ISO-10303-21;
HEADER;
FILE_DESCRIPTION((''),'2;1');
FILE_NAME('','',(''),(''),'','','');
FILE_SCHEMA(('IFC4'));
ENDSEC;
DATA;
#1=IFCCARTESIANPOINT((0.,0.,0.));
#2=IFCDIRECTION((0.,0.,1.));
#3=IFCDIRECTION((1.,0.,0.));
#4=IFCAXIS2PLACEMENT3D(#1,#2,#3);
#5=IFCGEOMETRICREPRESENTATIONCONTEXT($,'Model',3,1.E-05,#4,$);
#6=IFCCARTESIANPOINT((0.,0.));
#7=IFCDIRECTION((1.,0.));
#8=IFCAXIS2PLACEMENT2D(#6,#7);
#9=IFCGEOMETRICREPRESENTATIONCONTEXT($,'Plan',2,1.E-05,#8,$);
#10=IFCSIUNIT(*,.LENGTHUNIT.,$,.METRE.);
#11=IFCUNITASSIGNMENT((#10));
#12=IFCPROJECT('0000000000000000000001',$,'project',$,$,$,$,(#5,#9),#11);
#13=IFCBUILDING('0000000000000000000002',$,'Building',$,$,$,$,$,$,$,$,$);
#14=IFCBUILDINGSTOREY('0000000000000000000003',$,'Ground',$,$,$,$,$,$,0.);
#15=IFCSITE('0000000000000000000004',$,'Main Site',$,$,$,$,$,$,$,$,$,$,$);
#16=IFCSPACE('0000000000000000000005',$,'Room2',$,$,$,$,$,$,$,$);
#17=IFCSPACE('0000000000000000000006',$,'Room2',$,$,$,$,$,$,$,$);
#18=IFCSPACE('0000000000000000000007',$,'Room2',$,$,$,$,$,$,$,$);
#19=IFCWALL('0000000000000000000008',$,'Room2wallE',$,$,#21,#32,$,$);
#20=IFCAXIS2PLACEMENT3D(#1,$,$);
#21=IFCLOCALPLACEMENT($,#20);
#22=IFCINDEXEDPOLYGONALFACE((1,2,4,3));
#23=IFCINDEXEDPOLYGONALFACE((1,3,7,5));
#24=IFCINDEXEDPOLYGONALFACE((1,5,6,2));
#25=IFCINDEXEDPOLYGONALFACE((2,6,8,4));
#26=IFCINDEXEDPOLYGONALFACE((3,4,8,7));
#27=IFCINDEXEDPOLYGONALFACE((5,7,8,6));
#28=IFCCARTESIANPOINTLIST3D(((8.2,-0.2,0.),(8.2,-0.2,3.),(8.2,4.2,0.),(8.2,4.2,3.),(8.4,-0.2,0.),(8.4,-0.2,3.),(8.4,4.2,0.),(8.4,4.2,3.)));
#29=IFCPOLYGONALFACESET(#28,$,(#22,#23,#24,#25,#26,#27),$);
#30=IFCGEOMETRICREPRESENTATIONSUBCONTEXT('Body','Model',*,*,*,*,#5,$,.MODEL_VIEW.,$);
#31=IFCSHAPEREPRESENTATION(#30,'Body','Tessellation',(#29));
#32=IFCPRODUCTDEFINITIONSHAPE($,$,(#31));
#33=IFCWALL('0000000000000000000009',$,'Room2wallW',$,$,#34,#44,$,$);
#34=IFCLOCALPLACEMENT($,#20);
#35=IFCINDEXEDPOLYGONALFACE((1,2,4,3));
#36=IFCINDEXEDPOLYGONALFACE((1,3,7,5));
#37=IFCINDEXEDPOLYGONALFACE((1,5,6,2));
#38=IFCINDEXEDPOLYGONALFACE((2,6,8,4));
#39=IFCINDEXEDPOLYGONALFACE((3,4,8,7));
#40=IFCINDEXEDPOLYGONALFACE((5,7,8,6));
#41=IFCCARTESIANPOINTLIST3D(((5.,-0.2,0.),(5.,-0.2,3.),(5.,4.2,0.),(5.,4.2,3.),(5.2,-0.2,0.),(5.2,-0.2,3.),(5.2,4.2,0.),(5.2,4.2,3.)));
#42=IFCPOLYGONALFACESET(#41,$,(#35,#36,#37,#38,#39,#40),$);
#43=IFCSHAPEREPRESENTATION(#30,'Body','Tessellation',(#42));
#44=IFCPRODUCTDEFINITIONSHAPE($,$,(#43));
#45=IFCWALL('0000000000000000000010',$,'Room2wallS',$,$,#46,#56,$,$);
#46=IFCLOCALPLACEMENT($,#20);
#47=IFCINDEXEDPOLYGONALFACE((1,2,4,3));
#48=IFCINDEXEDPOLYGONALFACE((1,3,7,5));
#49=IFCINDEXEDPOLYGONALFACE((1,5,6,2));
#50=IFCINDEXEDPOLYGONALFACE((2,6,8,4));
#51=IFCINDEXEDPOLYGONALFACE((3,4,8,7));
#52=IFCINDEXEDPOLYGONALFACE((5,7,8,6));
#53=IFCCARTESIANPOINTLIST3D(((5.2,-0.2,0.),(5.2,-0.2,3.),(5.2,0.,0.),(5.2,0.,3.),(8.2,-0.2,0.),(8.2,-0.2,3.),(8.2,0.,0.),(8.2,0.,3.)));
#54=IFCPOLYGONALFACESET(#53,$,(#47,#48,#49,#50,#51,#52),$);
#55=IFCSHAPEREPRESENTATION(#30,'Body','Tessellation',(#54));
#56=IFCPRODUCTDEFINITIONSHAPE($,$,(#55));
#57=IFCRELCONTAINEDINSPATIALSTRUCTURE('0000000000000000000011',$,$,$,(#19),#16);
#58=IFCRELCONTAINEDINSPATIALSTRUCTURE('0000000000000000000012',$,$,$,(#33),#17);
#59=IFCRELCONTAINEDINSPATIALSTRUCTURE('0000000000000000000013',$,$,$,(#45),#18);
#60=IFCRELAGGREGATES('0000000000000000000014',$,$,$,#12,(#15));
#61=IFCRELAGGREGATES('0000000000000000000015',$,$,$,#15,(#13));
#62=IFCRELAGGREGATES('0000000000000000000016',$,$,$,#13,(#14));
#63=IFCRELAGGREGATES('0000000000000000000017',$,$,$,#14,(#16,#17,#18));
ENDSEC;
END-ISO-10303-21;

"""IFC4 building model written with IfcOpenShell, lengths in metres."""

from ifc_helpers import new_model, si_unit, frame, origin_with_axes, origin_2d_with_axis, place, context, subcontext, project, spatial, indexed_curve, outline, extrude, element, save


model = new_model("IFC4")

# Units and contexts
model_context = context("Model", 3, precision=1e-05, world=origin_with_axes())
plan_context = context("Plan", 2, precision=1e-05, world=origin_2d_with_axis())
body_context = subcontext(model_context, "Body", "Model", "MODEL_VIEW")
ifc_project = project(units=[si_unit("LENGTHUNIT", "METRE")], contexts=[model_context, plan_context])

# Site, building, storey, space
site = spatial("IfcSite", under=ifc_project, Name="Main Site")
building = spatial("IfcBuilding", under=site, Name="Building")
storey = spatial("IfcBuildingStorey", under=building, Name="Ground", Elevation=0.0)
space_1 = spatial("IfcSpace", under=storey, Name="Room2")

# Wall
wall_1_placement = place(None, frame((8.4, -0.2, 0.0), z_axis=(0.0, 0.0, 1.0), x_axis=(0.0, 1.0, 0.0)))
element("IfcWall", 1, at=wall_1_placement, inside=space_1, Name="Room2wallE", context=body_context, shape_type="SweptSolid", body=[
    extrude(outline(indexed_curve([(0.0, 0.0), (0.0, 0.2), (4.4, 0.2), (4.4, 0.0), (0.0, 0.0)], self_intersect=False)), origin_with_axes(), (0.0, 0.0, 1.0), 3.0),
])

# Shared definitions
space_2 = spatial("IfcSpace", under=storey, Name="Room2")

# Wall
for number, where, z_axis, x_axis, name in (
    (2, (5.2, -0.2, 0.0), (0.0, 0.0, 1.0), (0.0, 1.0, 0.0), "Room2wallW"),
):
    element("IfcWall", number, at=place(None, frame(where, z_axis=z_axis, x_axis=x_axis)), inside=space_2, Name=name, context=body_context, shape_type="SweptSolid", body=[
        extrude(outline(indexed_curve([(0.0, 0.0), (0.0, 0.2), (4.4, 0.2), (4.4, 0.0), (0.0, 0.0)], self_intersect=False)), origin_with_axes(), (0.0, 0.0, 1.0), 3.0),
    ])

# Shared definitions
space_3 = spatial("IfcSpace", under=storey, Name="Room2")

# Wall
wall_2_placement = place(None, frame((5.2, -0.2, 0.0), z_axis=(0.0, 0.0, 1.0), x_axis=(1.0, 0.0, 0.0)))
element("IfcWall", 3, at=wall_2_placement, inside=space_3, Name="Room2wallS", context=body_context, shape_type="SweptSolid", body=[
    extrude(outline(indexed_curve([(0.0, 0.0), (0.0, 0.2), (3.0, 0.2), (3.0, 0.0), (0.0, 0.0)], self_intersect=False)), origin_with_axes(), (0.0, 0.0, 1.0), 3.0),
])

save(model, "model.ifc")
